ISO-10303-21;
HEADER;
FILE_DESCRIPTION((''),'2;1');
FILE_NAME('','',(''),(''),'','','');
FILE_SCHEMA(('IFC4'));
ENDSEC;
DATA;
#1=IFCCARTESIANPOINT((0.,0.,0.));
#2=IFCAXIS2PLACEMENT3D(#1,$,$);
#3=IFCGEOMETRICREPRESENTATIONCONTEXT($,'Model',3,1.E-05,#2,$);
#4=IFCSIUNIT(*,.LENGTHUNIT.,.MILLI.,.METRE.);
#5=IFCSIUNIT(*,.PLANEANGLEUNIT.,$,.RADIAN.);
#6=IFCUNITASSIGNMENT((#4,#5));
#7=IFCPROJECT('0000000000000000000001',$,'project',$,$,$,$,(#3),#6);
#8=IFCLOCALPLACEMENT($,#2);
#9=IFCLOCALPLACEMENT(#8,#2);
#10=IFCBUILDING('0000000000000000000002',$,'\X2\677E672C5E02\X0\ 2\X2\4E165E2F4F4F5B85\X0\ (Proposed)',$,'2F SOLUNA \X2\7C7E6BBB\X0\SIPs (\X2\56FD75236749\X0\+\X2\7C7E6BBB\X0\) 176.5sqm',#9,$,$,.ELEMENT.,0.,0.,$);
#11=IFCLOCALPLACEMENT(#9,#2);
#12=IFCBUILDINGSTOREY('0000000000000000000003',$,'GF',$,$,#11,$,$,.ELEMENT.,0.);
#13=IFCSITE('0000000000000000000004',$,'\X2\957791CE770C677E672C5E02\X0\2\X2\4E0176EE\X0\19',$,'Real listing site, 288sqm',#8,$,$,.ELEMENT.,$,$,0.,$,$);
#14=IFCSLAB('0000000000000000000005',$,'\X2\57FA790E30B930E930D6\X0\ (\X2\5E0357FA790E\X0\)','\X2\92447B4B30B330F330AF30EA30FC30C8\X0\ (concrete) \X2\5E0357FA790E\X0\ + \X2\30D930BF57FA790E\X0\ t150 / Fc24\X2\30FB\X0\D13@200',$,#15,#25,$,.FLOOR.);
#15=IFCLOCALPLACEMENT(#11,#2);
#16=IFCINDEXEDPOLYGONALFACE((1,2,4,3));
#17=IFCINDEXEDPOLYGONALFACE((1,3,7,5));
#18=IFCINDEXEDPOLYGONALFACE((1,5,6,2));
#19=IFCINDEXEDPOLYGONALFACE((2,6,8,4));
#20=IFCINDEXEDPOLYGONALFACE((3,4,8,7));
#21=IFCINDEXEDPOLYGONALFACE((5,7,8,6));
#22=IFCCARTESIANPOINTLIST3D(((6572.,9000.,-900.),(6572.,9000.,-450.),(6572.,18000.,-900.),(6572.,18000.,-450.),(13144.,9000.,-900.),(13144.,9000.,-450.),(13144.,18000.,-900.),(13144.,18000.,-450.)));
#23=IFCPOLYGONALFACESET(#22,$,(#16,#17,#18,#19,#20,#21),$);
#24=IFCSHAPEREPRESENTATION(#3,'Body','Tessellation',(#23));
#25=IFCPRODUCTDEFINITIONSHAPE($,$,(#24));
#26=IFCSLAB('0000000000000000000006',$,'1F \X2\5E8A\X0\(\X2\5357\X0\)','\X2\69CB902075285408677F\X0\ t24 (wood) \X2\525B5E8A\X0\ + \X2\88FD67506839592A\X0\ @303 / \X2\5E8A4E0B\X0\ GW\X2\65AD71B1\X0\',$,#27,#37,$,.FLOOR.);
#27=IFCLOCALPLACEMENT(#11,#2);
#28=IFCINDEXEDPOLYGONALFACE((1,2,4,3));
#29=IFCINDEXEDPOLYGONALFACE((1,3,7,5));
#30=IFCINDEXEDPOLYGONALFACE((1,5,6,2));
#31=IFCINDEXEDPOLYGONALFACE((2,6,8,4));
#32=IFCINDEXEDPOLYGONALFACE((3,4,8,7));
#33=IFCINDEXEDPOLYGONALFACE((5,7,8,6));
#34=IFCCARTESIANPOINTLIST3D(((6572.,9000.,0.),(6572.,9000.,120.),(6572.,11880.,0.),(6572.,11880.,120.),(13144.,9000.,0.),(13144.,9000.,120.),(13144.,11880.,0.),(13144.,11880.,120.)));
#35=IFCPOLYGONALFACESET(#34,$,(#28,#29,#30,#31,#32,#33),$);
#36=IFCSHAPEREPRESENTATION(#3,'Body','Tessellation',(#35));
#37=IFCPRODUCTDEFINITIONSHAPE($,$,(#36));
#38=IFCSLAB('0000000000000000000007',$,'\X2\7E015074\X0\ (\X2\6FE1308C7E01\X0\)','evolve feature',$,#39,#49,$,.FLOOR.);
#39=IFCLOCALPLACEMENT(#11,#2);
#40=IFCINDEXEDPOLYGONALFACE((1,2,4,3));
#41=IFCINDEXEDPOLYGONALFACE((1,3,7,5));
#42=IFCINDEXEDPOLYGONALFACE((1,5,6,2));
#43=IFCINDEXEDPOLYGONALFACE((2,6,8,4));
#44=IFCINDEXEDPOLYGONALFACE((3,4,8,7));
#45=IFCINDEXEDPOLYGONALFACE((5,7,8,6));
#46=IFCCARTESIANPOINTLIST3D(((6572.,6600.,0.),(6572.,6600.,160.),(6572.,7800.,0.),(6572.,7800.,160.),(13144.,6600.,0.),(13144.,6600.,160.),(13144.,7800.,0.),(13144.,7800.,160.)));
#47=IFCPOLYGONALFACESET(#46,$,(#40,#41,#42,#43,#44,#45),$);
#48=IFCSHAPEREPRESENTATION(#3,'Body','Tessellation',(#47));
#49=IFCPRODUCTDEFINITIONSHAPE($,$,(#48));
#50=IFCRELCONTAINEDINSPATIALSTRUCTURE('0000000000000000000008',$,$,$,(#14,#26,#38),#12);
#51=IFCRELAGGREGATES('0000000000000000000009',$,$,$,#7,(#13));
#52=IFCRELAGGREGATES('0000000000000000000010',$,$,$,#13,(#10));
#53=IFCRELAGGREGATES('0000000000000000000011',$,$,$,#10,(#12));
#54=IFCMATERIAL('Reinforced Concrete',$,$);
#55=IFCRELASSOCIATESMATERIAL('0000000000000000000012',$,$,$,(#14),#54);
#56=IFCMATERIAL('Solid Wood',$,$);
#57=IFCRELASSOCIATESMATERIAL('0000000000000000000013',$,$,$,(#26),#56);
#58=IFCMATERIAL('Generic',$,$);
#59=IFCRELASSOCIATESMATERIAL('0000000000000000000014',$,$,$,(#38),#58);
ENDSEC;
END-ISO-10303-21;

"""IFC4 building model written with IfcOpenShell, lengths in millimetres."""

from ifc_helpers import new_model, si_unit, frame, frame_2d, origin, place, context, project, spatial, rectangle, extrude, material, element, save


model = new_model("IFC4")

# Units and contexts
model_context = context("Model", 3, precision=1e-05, world=origin())
ifc_project = project(units=[si_unit("LENGTHUNIT", "METRE", prefix="MILLI"), si_unit("PLANEANGLEUNIT", "RADIAN")], contexts=[model_context])

# Site, building, storey
site_placement = place(None, origin())
site = spatial("IfcSite", under=ifc_project, at=site_placement, Name="長野県松本市2丁目19", ObjectType="Real listing site, 288sqm", CompositionType="ELEMENT", RefElevation=0.0)
building_placement = place(site_placement, origin())
building = spatial("IfcBuilding", under=site, at=building_placement, Name="松本市 2世帯住宅 (Proposed)", ObjectType="2F SOLUNA 籾殻SIPs (国産杉+籾殻) 176.5sqm", CompositionType="ELEMENT", ElevationOfRefHeight=0.0, ElevationOfTerrain=0.0)
storey_placement = place(building_placement, origin())
storey = spatial("IfcBuildingStorey", under=building, at=storey_placement, Name="GF", CompositionType="ELEMENT", Elevation=0.0)

# Slabs
ifc_material_1 = material(Name="Reinforced Concrete")
slab_1_placement = place(storey_placement, frame((3286.0, 4500.0, -450.0)))
element("IfcSlab", 1, at=slab_1_placement, inside=storey, material=ifc_material_1, Name="基礎スラブ (布基礎)", Description="鉄筋コンクリート (concrete) 布基礎 + ベタ基礎 t150 / Fc24・D13@200", PredefinedType="FLOOR", context=model_context, shape_type="SweptSolid", body=[
    extrude(rectangle(XDim=6572.0, YDim=9000.0, at=frame_2d((3286.0, 4500.0))), frame((3286.0, 4500.0, -450.0)), (0.0, 0.0, 1.0), 450.0),
])
ifc_material_2 = material(Name="Solid Wood")
slab_2_placement = place(storey_placement, frame((3286.0, 4500.0, 0.0)))
element("IfcSlab", 2, at=slab_2_placement, inside=storey, material=ifc_material_2, Name="1F 床(南)", Description="構造用合板 t24 (wood) 剛床 + 製材根太 @303 / 床下 GW断熱", PredefinedType="FLOOR", context=model_context, shape_type="SweptSolid", body=[
    extrude(rectangle(XDim=6572.0, YDim=2880.0, at=frame_2d((3286.0, 1440.0))), frame((3286.0, 4500.0, 0.0)), (0.0, 0.0, 1.0), 120.0),
])
ifc_material_3 = material(Name="Generic")
slab_3_placement = place(storey_placement, frame((3286.0, 3300.0, 0.0)))
element("IfcSlab", 3, at=slab_3_placement, inside=storey, material=ifc_material_3, Name="縁側 (濡れ縁)", Description="evolve feature", PredefinedType="FLOOR", context=model_context, shape_type="SweptSolid", body=[
    extrude(rectangle(XDim=6572.0, YDim=1200.0, at=frame_2d((3286.0, 600.0))), frame((3286.0, 3300.0, 0.0)), (0.0, 0.0, 1.0), 160.0),
])

save(model, "model.ifc")
